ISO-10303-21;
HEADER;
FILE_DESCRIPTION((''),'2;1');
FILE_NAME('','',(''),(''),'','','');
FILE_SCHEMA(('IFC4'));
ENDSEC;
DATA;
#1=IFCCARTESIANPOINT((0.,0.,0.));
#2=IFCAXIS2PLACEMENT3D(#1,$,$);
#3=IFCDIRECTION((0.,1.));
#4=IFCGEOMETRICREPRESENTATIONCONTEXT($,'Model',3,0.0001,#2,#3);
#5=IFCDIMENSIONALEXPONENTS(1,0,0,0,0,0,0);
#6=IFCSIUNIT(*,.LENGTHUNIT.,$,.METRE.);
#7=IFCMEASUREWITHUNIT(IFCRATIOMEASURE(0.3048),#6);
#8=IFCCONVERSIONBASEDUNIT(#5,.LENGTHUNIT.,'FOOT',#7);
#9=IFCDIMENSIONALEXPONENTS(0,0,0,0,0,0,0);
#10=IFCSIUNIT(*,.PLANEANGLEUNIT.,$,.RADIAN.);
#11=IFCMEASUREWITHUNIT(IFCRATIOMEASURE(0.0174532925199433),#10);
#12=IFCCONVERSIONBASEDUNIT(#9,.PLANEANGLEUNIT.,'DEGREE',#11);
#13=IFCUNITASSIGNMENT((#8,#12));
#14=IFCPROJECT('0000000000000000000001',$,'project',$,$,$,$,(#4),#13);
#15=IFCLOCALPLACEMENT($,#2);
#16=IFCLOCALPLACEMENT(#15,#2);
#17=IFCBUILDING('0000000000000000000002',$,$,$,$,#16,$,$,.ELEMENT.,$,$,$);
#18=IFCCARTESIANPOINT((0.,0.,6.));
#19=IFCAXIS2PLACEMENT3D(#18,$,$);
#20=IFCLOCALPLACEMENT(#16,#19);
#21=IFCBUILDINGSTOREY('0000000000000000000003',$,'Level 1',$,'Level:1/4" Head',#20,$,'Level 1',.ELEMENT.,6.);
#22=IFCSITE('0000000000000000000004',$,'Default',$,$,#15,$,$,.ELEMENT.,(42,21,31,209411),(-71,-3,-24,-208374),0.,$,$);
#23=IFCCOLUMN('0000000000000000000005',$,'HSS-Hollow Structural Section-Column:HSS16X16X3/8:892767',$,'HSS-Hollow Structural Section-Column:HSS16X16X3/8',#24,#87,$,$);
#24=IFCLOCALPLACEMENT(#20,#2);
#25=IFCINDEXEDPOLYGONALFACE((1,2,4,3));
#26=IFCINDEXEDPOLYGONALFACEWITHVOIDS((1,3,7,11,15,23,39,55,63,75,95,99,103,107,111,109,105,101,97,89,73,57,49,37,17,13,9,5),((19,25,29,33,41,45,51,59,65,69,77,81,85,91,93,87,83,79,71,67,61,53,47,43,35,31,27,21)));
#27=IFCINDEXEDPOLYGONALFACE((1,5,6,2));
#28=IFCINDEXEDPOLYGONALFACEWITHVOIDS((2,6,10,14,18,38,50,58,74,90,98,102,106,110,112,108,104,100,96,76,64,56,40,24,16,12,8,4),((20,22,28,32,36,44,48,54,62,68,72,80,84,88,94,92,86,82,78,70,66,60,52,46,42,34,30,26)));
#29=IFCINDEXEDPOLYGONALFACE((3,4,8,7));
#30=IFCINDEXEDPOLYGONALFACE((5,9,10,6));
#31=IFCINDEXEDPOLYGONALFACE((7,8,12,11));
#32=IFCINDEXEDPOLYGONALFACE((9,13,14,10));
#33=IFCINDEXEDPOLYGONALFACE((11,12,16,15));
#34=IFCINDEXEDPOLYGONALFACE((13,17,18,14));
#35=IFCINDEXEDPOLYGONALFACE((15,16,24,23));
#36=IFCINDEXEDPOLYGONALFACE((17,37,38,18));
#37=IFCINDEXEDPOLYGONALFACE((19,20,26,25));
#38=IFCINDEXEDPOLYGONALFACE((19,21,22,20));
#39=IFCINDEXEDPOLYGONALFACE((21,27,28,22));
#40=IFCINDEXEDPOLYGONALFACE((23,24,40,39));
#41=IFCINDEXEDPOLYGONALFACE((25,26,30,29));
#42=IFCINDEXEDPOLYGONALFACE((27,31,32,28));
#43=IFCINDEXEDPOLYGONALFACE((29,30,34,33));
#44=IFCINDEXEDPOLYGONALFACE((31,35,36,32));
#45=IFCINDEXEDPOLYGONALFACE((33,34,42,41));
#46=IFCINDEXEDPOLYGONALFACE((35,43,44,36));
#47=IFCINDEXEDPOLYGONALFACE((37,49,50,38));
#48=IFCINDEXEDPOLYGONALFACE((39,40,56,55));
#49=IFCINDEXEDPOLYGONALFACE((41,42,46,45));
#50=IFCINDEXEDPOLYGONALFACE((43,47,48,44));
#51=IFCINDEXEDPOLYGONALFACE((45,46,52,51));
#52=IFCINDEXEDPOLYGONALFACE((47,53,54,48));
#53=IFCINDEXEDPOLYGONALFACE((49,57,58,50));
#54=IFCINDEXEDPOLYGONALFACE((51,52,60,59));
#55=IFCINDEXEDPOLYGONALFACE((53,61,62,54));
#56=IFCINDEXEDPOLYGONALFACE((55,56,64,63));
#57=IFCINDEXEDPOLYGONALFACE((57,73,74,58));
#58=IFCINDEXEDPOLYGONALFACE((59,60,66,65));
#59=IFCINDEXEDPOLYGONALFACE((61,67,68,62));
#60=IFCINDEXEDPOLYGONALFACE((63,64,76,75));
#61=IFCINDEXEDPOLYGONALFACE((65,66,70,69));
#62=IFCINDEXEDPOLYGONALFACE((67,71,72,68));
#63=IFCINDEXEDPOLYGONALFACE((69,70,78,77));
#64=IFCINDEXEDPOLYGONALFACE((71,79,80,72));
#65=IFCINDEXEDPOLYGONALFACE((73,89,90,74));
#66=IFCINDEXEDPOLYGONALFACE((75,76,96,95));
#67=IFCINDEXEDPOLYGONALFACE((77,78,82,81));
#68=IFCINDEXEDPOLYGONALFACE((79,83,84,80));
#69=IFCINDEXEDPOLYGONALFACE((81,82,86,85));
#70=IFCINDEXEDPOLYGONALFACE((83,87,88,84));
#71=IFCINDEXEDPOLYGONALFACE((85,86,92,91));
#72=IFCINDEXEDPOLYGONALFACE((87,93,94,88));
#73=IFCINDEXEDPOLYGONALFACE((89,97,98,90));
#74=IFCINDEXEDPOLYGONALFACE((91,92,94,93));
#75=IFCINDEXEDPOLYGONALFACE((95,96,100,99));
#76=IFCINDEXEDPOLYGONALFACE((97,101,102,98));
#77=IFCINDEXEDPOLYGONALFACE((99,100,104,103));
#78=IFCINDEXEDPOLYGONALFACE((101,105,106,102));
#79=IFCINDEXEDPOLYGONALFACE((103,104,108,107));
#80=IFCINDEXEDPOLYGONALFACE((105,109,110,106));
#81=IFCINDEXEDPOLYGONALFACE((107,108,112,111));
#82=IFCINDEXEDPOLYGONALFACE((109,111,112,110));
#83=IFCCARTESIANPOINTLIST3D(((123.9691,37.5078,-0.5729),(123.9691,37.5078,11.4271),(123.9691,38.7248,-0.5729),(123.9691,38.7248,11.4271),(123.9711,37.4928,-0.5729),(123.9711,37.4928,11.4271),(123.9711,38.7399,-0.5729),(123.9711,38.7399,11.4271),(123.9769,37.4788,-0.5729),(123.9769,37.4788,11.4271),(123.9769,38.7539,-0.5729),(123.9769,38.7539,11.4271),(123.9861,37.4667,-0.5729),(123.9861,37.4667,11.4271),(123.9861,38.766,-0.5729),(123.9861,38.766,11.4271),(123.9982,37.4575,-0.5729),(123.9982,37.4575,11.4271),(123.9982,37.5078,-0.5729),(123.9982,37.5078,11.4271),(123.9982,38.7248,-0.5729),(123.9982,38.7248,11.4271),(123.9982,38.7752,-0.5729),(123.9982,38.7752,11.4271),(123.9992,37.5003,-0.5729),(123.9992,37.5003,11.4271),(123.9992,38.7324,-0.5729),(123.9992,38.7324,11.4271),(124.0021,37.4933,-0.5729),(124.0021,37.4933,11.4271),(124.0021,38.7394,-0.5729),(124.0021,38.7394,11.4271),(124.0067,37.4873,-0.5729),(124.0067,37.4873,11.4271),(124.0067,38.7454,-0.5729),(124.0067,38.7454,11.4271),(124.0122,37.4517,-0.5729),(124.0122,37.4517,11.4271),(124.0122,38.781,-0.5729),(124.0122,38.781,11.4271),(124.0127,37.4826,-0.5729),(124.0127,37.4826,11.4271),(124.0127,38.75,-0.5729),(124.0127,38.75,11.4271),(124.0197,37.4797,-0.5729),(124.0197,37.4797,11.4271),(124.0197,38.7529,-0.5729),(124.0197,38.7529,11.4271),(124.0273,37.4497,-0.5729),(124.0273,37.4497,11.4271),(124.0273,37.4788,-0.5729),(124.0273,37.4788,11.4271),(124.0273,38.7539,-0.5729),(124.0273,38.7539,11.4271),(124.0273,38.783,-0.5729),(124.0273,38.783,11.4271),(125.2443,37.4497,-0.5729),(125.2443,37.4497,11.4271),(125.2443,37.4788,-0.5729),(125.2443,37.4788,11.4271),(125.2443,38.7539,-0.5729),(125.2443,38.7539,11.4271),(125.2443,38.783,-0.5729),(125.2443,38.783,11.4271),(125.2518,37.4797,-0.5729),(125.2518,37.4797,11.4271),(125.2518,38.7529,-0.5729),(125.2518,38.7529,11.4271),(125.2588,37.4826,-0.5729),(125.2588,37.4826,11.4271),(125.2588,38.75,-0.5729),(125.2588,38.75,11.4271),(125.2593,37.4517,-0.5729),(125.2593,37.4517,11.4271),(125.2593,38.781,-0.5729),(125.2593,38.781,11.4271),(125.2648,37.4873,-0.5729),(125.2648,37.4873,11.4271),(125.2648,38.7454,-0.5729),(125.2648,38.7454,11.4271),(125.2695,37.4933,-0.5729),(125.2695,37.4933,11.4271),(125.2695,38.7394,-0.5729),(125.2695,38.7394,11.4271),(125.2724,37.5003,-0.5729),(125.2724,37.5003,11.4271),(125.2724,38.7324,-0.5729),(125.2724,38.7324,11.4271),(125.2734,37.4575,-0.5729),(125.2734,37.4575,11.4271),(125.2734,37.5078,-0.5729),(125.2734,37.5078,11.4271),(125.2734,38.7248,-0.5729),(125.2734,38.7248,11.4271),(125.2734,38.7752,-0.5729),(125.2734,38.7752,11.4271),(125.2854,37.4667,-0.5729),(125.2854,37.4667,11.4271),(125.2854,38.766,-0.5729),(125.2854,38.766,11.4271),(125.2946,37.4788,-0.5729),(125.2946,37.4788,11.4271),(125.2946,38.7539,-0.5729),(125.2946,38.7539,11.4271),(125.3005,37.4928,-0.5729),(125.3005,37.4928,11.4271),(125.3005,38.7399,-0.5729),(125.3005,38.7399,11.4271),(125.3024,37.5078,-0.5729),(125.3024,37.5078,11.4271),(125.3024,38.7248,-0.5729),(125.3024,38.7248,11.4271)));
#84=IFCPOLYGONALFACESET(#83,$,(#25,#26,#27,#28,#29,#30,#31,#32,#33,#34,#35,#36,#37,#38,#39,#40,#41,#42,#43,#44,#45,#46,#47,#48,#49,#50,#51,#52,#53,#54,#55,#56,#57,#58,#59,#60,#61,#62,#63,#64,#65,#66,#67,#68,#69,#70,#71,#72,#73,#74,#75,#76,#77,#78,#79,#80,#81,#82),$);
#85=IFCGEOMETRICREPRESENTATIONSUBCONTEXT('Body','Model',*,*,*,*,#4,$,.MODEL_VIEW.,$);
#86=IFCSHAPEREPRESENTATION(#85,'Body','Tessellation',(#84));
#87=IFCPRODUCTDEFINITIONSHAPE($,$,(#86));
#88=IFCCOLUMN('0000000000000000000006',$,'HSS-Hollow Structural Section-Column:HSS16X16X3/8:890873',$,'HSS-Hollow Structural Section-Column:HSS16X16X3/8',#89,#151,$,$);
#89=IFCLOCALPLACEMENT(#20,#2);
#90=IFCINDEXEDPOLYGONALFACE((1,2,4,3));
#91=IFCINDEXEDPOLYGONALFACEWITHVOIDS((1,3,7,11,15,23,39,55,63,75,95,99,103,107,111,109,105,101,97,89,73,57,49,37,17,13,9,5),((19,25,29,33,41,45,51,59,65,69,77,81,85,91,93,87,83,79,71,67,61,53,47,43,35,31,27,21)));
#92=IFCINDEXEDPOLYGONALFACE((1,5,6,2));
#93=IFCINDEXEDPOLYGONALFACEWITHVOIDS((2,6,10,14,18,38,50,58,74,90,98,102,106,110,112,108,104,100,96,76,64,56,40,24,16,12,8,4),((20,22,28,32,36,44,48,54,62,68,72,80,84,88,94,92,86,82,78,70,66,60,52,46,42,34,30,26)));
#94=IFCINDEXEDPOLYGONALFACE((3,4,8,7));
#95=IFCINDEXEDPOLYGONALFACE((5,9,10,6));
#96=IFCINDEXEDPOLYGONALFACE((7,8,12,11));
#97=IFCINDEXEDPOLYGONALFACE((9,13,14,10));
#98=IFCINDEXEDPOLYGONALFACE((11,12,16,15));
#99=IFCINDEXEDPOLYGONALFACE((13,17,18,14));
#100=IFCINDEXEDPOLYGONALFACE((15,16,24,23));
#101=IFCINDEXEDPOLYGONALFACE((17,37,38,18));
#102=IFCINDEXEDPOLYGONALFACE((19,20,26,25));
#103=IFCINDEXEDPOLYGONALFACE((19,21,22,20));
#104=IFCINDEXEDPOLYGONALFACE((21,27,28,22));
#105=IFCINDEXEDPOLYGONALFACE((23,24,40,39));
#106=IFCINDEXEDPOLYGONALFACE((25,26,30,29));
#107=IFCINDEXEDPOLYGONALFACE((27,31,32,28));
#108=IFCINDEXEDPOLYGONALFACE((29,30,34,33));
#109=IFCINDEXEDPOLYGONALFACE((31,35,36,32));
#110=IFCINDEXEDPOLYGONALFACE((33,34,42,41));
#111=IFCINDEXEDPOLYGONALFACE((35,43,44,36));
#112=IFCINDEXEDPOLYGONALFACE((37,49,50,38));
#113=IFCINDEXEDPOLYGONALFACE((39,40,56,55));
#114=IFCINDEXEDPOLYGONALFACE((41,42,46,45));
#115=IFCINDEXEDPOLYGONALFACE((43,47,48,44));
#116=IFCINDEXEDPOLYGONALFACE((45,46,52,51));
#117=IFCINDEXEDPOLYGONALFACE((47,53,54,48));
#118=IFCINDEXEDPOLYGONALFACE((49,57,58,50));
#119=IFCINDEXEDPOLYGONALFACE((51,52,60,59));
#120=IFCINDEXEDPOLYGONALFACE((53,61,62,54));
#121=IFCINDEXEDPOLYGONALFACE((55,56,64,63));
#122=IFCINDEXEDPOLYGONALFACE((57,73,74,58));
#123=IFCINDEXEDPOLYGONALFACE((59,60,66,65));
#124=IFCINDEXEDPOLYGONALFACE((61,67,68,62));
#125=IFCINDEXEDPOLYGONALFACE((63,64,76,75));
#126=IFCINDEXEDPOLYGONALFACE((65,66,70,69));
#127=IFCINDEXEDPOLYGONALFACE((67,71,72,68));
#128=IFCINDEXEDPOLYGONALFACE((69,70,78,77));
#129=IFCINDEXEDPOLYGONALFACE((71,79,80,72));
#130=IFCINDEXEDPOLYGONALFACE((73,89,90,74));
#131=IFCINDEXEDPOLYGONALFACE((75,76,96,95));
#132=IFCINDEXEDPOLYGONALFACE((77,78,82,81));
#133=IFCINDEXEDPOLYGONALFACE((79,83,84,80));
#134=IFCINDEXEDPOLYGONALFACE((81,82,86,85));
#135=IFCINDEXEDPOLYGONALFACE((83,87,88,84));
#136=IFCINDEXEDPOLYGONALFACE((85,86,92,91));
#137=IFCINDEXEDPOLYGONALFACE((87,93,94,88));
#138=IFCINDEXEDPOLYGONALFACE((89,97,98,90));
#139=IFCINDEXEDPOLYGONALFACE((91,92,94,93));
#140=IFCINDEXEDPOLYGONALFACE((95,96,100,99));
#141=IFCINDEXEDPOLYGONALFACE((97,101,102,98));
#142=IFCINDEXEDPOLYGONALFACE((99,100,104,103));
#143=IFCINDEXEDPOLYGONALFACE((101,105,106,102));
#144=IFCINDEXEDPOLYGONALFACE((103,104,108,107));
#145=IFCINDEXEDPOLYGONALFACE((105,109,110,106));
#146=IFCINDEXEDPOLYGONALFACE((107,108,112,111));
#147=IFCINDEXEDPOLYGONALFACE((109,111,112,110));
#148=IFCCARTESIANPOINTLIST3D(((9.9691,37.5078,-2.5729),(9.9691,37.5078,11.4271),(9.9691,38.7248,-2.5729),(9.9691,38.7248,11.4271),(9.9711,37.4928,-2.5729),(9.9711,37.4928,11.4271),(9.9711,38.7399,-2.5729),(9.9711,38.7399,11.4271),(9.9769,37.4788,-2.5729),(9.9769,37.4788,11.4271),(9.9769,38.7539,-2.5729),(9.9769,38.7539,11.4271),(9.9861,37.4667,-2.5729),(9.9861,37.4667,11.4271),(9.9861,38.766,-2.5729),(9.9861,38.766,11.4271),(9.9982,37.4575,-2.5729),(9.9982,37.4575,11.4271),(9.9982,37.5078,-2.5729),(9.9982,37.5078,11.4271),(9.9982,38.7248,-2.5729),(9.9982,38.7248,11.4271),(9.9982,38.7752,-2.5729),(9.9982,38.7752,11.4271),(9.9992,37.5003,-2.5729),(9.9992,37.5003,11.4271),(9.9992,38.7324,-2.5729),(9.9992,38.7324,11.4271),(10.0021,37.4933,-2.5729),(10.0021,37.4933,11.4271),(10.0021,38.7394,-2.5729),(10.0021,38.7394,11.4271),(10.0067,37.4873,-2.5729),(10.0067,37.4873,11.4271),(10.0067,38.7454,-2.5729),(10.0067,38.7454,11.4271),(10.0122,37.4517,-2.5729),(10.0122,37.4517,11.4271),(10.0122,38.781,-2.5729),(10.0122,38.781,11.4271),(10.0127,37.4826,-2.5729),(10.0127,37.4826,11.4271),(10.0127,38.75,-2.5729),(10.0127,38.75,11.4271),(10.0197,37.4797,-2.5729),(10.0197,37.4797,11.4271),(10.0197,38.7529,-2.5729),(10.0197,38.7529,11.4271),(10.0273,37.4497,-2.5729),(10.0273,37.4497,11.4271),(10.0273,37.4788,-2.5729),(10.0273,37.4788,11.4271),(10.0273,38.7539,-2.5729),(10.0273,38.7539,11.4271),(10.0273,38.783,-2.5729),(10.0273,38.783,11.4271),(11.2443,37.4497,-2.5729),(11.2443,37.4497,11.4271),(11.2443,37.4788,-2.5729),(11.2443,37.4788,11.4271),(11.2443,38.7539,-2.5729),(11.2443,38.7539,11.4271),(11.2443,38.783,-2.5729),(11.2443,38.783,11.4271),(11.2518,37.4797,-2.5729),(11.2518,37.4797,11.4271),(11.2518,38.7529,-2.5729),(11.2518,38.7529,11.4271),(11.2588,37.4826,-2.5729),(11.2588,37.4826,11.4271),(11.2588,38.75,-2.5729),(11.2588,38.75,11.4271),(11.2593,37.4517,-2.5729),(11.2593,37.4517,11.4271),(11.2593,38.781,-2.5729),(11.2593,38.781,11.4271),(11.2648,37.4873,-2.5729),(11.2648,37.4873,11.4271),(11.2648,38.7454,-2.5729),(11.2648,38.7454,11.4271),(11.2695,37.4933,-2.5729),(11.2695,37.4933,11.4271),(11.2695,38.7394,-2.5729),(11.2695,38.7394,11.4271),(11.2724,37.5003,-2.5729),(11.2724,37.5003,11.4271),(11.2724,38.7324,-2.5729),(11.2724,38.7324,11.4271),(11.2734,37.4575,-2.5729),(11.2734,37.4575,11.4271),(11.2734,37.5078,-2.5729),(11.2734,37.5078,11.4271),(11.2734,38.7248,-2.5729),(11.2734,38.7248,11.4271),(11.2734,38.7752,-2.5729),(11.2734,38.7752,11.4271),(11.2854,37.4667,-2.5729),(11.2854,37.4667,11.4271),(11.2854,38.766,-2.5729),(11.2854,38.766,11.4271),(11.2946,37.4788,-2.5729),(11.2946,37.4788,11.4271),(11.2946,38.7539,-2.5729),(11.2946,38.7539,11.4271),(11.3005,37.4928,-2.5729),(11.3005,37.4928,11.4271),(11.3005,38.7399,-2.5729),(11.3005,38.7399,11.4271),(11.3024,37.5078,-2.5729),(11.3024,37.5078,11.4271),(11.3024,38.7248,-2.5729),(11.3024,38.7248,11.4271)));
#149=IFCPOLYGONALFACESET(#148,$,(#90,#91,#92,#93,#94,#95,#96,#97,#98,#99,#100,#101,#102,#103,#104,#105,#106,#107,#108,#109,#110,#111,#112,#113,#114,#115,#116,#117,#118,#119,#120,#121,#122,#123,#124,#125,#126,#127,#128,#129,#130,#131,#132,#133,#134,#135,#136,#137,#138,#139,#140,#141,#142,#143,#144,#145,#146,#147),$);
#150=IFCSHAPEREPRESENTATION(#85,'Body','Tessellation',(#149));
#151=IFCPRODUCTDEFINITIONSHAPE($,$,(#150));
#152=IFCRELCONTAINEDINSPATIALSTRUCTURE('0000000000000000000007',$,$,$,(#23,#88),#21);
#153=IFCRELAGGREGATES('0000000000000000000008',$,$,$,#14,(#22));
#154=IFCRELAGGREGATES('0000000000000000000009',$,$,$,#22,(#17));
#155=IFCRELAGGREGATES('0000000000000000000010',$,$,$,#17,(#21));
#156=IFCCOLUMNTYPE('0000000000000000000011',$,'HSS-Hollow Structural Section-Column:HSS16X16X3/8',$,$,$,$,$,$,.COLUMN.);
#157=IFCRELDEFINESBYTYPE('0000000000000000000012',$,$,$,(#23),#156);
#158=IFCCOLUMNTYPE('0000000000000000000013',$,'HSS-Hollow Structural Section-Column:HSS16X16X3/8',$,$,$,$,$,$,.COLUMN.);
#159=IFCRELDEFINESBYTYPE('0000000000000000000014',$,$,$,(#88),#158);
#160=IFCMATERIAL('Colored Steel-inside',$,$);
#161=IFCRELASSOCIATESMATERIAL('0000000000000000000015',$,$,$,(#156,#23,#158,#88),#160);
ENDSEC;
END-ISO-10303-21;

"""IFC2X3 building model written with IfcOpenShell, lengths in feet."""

from ifc_helpers import new_model, entity, si_unit, converted_unit, direction, frame, frame_2d, origin, place, context, subcontext, project, spatial, polyline, circle_curve, parameter, trimmed, segment, composite_curve, outline, extrude, source, transform, mapped, material, type_object, type_shapes, element, save


model = new_model("IFC2X3")

# Units and contexts
model_context = context("Model", 3, precision=0.0001, world=origin(), true_north=direction((0.0, 1.0)))
body_context = subcontext(model_context, "Body", "Model", "MODEL_VIEW")
ifc_project = project(units=[converted_unit("LENGTHUNIT", "FOOT", entity("IfcRatioMeasure", 0.3048), si_unit("LENGTHUNIT", "METRE"), dimensions=[1, 0, 0, 0, 0, 0, 0]), converted_unit("PLANEANGLEUNIT", "DEGREE", entity("IfcRatioMeasure", 0.0174532925199433), si_unit("PLANEANGLEUNIT", "RADIAN"), dimensions=[0, 0, 0, 0, 0, 0, 0])], contexts=[model_context])

# Site, building, storey
site_placement = place(None, origin())
site = spatial("IfcSite", under=ifc_project, at=site_placement, Name="Default", CompositionType="ELEMENT", RefLatitude=(42, 21, 31, 209411), RefLongitude=(-71, -3, -24, -208374), RefElevation=0.0)
building_placement = place(site_placement, origin())
building = spatial("IfcBuilding", under=site, at=building_placement, CompositionType="ELEMENT")
storey_placement = place(building_placement, frame((0.0, 0.0, 6.0)))
storey = spatial("IfcBuildingStorey", under=building, at=storey_placement, Name="Level 1", ObjectType="Level:1/4\" Head", LongName="Level 1", CompositionType="ELEMENT", Elevation=6.0)

# Columns
ifc_material_1 = material(Name="Colored Steel-inside")
column_type_1 = type_object("IfcColumnType", Name="HSS-Hollow Structural Section-Column:HSS16X16X3/8", PredefinedType="COLUMN", material=ifc_material_1)
shared_shape_1 = source(origin(), body_context, "Body", "SweptSolid", [
    extrude(outline(composite_curve([segment(polyline([(-0.6085, -0.6667), (0.6085, -0.6667)]), True, "CONTINUOUS"), segment(trimmed(circle_curve(frame_2d((0.6085, -0.6085), x_axis=(-1.0, 0.0)), 0.0582), [parameter(90.0)], [parameter(180.0)], True, "PARAMETER"), True, "CONTINUOUS"), segment(polyline([(0.6667, -0.6085), (0.6667, 0.6085)]), True, "CONTINUOUS"), segment(trimmed(circle_curve(frame_2d((0.6085, 0.6085), x_axis=(-1.0, 0.0)), 0.0582), [parameter(180.0)], [parameter(270.0)], True, "PARAMETER"), True, "CONTINUOUS"), segment(polyline([(0.6085, 0.6667), (-0.6085, 0.6667)]), True, "CONTINUOUS"), segment(trimmed(circle_curve(frame_2d((-0.6085, 0.6085), x_axis=(-1.0, 0.0)), 0.0582), [parameter(270.0)], [parameter(360.0)], True, "PARAMETER"), True, "CONTINUOUS"), segment(polyline([(-0.6667, 0.6085), (-0.6667, -0.6085)]), True, "CONTINUOUS"), segment(trimmed(circle_curve(frame_2d((-0.6085, -0.6085), x_axis=(-1.0, 0.0)), 0.0582), [parameter(360.0)], [parameter(90.0)], True, "PARAMETER"), True, "CONTINUOUS")], self_intersect=False), holes=[composite_curve([segment(trimmed(circle_curve(frame_2d((-0.6085, -0.6085), x_axis=(-1.0, 0.0)), 0.0291), [parameter(0.0)], [parameter(90.0)], True, "PARAMETER"), False, "CONTINUOUS"), segment(polyline([(-0.6376, -0.6085), (-0.6376, 0.6085)]), True, "CONTINUOUS"), segment(trimmed(circle_curve(frame_2d((-0.6085, 0.6085), x_axis=(-1.0, 0.0)), 0.0291), [parameter(270.0)], [parameter(360.0)], True, "PARAMETER"), False, "CONTINUOUS"), segment(polyline([(-0.6085, 0.6376), (0.6085, 0.6376)]), True, "CONTINUOUS"), segment(trimmed(circle_curve(frame_2d((0.6085, 0.6085), x_axis=(-1.0, 0.0)), 0.0291), [parameter(180.0)], [parameter(270.0)], True, "PARAMETER"), False, "CONTINUOUS"), segment(polyline([(0.6376, 0.6085), (0.6376, -0.6085)]), True, "CONTINUOUS"), segment(trimmed(circle_curve(frame_2d((0.6085, -0.6085), x_axis=(-1.0, 0.0)), 0.0291), [parameter(90.0)], [parameter(180.0)], True, "PARAMETER"), False, "CONTINUOUS"), segment(polyline([(0.6085, -0.6376), (-0.6085, -0.6376)]), True, "CONTINUOUS")], self_intersect=False)]), frame((0.0, 0.0, 5.4271), z_axis=(0.0, 0.0, 1.0), x_axis=(-1.0, 0.0, 0.0)), (0.0, 0.0, 1.0), 12.0),
])
type_shapes(column_type_1, [shared_shape_1])
column_1_placement = place(storey_placement, frame((124.6358, 38.1163, -6.0), z_axis=(0.0, 0.0, 1.0), x_axis=(0.0, 1.0, 0.0)))
element("IfcColumn", 1, at=column_1_placement, inside=storey, type_object=column_type_1, material=ifc_material_1, Name="HSS-Hollow Structural Section-Column:HSS16X16X3/8:892767", ObjectType="HSS-Hollow Structural Section-Column:HSS16X16X3/8", context=body_context, shape_type="MappedRepresentation", body=[
    mapped(shared_shape_1, transform((0.0, 0.0, 0.0), scale=1.0)),
])
column_type_2 = type_object("IfcColumnType", Name="HSS-Hollow Structural Section-Column:HSS16X16X3/8", PredefinedType="COLUMN", material=ifc_material_1)
shared_shape_2 = source(origin(), body_context, "Body", "SweptSolid", [
    extrude(outline(composite_curve([segment(polyline([(-0.6085, -0.6667), (0.6085, -0.6667)]), True, "CONTINUOUS"), segment(trimmed(circle_curve(frame_2d((0.6085, -0.6085), x_axis=(-1.0, 0.0)), 0.0582), [parameter(90.0)], [parameter(180.0)], True, "PARAMETER"), True, "CONTINUOUS"), segment(polyline([(0.6667, -0.6085), (0.6667, 0.6085)]), True, "CONTINUOUS"), segment(trimmed(circle_curve(frame_2d((0.6085, 0.6085), x_axis=(-1.0, 0.0)), 0.0582), [parameter(180.0)], [parameter(270.0)], True, "PARAMETER"), True, "CONTINUOUS"), segment(polyline([(0.6085, 0.6667), (-0.6085, 0.6667)]), True, "CONTINUOUS"), segment(trimmed(circle_curve(frame_2d((-0.6085, 0.6085), x_axis=(-1.0, 0.0)), 0.0582), [parameter(270.0)], [parameter(360.0)], True, "PARAMETER"), True, "CONTINUOUS"), segment(polyline([(-0.6667, 0.6085), (-0.6667, -0.6085)]), True, "CONTINUOUS"), segment(trimmed(circle_curve(frame_2d((-0.6085, -0.6085), x_axis=(-1.0, 0.0)), 0.0582), [parameter(360.0)], [parameter(90.0)], True, "PARAMETER"), True, "CONTINUOUS")], self_intersect=False), holes=[composite_curve([segment(trimmed(circle_curve(frame_2d((-0.6085, -0.6085), x_axis=(-1.0, 0.0)), 0.0291), [parameter(0.0)], [parameter(90.0)], True, "PARAMETER"), False, "CONTINUOUS"), segment(polyline([(-0.6376, -0.6085), (-0.6376, 0.6085)]), True, "CONTINUOUS"), segment(trimmed(circle_curve(frame_2d((-0.6085, 0.6085), x_axis=(-1.0, 0.0)), 0.0291), [parameter(270.0)], [parameter(360.0)], True, "PARAMETER"), False, "CONTINUOUS"), segment(polyline([(-0.6085, 0.6376), (0.6085, 0.6376)]), True, "CONTINUOUS"), segment(trimmed(circle_curve(frame_2d((0.6085, 0.6085), x_axis=(-1.0, 0.0)), 0.0291), [parameter(180.0)], [parameter(270.0)], True, "PARAMETER"), False, "CONTINUOUS"), segment(polyline([(0.6376, 0.6085), (0.6376, -0.6085)]), True, "CONTINUOUS"), segment(trimmed(circle_curve(frame_2d((0.6085, -0.6085), x_axis=(-1.0, 0.0)), 0.0291), [parameter(90.0)], [parameter(180.0)], True, "PARAMETER"), False, "CONTINUOUS"), segment(polyline([(0.6085, -0.6376), (-0.6085, -0.6376)]), True, "CONTINUOUS")], self_intersect=False)]), frame((0.0, 0.0, 3.4271), z_axis=(0.0, 0.0, 1.0), x_axis=(-1.0, 0.0, 0.0)), (0.0, 0.0, 1.0), 14.0),
])
type_shapes(column_type_2, [shared_shape_2])
column_2_placement = place(storey_placement, frame((10.6358, 38.1163, -6.0)))
element("IfcColumn", 2, at=column_2_placement, inside=storey, type_object=column_type_2, material=ifc_material_1, Name="HSS-Hollow Structural Section-Column:HSS16X16X3/8:890873", ObjectType="HSS-Hollow Structural Section-Column:HSS16X16X3/8", context=body_context, shape_type="MappedRepresentation", body=[
    mapped(shared_shape_2, transform((0.0, 0.0, 0.0), scale=1.0)),
])

save(model, "model.ifc")
